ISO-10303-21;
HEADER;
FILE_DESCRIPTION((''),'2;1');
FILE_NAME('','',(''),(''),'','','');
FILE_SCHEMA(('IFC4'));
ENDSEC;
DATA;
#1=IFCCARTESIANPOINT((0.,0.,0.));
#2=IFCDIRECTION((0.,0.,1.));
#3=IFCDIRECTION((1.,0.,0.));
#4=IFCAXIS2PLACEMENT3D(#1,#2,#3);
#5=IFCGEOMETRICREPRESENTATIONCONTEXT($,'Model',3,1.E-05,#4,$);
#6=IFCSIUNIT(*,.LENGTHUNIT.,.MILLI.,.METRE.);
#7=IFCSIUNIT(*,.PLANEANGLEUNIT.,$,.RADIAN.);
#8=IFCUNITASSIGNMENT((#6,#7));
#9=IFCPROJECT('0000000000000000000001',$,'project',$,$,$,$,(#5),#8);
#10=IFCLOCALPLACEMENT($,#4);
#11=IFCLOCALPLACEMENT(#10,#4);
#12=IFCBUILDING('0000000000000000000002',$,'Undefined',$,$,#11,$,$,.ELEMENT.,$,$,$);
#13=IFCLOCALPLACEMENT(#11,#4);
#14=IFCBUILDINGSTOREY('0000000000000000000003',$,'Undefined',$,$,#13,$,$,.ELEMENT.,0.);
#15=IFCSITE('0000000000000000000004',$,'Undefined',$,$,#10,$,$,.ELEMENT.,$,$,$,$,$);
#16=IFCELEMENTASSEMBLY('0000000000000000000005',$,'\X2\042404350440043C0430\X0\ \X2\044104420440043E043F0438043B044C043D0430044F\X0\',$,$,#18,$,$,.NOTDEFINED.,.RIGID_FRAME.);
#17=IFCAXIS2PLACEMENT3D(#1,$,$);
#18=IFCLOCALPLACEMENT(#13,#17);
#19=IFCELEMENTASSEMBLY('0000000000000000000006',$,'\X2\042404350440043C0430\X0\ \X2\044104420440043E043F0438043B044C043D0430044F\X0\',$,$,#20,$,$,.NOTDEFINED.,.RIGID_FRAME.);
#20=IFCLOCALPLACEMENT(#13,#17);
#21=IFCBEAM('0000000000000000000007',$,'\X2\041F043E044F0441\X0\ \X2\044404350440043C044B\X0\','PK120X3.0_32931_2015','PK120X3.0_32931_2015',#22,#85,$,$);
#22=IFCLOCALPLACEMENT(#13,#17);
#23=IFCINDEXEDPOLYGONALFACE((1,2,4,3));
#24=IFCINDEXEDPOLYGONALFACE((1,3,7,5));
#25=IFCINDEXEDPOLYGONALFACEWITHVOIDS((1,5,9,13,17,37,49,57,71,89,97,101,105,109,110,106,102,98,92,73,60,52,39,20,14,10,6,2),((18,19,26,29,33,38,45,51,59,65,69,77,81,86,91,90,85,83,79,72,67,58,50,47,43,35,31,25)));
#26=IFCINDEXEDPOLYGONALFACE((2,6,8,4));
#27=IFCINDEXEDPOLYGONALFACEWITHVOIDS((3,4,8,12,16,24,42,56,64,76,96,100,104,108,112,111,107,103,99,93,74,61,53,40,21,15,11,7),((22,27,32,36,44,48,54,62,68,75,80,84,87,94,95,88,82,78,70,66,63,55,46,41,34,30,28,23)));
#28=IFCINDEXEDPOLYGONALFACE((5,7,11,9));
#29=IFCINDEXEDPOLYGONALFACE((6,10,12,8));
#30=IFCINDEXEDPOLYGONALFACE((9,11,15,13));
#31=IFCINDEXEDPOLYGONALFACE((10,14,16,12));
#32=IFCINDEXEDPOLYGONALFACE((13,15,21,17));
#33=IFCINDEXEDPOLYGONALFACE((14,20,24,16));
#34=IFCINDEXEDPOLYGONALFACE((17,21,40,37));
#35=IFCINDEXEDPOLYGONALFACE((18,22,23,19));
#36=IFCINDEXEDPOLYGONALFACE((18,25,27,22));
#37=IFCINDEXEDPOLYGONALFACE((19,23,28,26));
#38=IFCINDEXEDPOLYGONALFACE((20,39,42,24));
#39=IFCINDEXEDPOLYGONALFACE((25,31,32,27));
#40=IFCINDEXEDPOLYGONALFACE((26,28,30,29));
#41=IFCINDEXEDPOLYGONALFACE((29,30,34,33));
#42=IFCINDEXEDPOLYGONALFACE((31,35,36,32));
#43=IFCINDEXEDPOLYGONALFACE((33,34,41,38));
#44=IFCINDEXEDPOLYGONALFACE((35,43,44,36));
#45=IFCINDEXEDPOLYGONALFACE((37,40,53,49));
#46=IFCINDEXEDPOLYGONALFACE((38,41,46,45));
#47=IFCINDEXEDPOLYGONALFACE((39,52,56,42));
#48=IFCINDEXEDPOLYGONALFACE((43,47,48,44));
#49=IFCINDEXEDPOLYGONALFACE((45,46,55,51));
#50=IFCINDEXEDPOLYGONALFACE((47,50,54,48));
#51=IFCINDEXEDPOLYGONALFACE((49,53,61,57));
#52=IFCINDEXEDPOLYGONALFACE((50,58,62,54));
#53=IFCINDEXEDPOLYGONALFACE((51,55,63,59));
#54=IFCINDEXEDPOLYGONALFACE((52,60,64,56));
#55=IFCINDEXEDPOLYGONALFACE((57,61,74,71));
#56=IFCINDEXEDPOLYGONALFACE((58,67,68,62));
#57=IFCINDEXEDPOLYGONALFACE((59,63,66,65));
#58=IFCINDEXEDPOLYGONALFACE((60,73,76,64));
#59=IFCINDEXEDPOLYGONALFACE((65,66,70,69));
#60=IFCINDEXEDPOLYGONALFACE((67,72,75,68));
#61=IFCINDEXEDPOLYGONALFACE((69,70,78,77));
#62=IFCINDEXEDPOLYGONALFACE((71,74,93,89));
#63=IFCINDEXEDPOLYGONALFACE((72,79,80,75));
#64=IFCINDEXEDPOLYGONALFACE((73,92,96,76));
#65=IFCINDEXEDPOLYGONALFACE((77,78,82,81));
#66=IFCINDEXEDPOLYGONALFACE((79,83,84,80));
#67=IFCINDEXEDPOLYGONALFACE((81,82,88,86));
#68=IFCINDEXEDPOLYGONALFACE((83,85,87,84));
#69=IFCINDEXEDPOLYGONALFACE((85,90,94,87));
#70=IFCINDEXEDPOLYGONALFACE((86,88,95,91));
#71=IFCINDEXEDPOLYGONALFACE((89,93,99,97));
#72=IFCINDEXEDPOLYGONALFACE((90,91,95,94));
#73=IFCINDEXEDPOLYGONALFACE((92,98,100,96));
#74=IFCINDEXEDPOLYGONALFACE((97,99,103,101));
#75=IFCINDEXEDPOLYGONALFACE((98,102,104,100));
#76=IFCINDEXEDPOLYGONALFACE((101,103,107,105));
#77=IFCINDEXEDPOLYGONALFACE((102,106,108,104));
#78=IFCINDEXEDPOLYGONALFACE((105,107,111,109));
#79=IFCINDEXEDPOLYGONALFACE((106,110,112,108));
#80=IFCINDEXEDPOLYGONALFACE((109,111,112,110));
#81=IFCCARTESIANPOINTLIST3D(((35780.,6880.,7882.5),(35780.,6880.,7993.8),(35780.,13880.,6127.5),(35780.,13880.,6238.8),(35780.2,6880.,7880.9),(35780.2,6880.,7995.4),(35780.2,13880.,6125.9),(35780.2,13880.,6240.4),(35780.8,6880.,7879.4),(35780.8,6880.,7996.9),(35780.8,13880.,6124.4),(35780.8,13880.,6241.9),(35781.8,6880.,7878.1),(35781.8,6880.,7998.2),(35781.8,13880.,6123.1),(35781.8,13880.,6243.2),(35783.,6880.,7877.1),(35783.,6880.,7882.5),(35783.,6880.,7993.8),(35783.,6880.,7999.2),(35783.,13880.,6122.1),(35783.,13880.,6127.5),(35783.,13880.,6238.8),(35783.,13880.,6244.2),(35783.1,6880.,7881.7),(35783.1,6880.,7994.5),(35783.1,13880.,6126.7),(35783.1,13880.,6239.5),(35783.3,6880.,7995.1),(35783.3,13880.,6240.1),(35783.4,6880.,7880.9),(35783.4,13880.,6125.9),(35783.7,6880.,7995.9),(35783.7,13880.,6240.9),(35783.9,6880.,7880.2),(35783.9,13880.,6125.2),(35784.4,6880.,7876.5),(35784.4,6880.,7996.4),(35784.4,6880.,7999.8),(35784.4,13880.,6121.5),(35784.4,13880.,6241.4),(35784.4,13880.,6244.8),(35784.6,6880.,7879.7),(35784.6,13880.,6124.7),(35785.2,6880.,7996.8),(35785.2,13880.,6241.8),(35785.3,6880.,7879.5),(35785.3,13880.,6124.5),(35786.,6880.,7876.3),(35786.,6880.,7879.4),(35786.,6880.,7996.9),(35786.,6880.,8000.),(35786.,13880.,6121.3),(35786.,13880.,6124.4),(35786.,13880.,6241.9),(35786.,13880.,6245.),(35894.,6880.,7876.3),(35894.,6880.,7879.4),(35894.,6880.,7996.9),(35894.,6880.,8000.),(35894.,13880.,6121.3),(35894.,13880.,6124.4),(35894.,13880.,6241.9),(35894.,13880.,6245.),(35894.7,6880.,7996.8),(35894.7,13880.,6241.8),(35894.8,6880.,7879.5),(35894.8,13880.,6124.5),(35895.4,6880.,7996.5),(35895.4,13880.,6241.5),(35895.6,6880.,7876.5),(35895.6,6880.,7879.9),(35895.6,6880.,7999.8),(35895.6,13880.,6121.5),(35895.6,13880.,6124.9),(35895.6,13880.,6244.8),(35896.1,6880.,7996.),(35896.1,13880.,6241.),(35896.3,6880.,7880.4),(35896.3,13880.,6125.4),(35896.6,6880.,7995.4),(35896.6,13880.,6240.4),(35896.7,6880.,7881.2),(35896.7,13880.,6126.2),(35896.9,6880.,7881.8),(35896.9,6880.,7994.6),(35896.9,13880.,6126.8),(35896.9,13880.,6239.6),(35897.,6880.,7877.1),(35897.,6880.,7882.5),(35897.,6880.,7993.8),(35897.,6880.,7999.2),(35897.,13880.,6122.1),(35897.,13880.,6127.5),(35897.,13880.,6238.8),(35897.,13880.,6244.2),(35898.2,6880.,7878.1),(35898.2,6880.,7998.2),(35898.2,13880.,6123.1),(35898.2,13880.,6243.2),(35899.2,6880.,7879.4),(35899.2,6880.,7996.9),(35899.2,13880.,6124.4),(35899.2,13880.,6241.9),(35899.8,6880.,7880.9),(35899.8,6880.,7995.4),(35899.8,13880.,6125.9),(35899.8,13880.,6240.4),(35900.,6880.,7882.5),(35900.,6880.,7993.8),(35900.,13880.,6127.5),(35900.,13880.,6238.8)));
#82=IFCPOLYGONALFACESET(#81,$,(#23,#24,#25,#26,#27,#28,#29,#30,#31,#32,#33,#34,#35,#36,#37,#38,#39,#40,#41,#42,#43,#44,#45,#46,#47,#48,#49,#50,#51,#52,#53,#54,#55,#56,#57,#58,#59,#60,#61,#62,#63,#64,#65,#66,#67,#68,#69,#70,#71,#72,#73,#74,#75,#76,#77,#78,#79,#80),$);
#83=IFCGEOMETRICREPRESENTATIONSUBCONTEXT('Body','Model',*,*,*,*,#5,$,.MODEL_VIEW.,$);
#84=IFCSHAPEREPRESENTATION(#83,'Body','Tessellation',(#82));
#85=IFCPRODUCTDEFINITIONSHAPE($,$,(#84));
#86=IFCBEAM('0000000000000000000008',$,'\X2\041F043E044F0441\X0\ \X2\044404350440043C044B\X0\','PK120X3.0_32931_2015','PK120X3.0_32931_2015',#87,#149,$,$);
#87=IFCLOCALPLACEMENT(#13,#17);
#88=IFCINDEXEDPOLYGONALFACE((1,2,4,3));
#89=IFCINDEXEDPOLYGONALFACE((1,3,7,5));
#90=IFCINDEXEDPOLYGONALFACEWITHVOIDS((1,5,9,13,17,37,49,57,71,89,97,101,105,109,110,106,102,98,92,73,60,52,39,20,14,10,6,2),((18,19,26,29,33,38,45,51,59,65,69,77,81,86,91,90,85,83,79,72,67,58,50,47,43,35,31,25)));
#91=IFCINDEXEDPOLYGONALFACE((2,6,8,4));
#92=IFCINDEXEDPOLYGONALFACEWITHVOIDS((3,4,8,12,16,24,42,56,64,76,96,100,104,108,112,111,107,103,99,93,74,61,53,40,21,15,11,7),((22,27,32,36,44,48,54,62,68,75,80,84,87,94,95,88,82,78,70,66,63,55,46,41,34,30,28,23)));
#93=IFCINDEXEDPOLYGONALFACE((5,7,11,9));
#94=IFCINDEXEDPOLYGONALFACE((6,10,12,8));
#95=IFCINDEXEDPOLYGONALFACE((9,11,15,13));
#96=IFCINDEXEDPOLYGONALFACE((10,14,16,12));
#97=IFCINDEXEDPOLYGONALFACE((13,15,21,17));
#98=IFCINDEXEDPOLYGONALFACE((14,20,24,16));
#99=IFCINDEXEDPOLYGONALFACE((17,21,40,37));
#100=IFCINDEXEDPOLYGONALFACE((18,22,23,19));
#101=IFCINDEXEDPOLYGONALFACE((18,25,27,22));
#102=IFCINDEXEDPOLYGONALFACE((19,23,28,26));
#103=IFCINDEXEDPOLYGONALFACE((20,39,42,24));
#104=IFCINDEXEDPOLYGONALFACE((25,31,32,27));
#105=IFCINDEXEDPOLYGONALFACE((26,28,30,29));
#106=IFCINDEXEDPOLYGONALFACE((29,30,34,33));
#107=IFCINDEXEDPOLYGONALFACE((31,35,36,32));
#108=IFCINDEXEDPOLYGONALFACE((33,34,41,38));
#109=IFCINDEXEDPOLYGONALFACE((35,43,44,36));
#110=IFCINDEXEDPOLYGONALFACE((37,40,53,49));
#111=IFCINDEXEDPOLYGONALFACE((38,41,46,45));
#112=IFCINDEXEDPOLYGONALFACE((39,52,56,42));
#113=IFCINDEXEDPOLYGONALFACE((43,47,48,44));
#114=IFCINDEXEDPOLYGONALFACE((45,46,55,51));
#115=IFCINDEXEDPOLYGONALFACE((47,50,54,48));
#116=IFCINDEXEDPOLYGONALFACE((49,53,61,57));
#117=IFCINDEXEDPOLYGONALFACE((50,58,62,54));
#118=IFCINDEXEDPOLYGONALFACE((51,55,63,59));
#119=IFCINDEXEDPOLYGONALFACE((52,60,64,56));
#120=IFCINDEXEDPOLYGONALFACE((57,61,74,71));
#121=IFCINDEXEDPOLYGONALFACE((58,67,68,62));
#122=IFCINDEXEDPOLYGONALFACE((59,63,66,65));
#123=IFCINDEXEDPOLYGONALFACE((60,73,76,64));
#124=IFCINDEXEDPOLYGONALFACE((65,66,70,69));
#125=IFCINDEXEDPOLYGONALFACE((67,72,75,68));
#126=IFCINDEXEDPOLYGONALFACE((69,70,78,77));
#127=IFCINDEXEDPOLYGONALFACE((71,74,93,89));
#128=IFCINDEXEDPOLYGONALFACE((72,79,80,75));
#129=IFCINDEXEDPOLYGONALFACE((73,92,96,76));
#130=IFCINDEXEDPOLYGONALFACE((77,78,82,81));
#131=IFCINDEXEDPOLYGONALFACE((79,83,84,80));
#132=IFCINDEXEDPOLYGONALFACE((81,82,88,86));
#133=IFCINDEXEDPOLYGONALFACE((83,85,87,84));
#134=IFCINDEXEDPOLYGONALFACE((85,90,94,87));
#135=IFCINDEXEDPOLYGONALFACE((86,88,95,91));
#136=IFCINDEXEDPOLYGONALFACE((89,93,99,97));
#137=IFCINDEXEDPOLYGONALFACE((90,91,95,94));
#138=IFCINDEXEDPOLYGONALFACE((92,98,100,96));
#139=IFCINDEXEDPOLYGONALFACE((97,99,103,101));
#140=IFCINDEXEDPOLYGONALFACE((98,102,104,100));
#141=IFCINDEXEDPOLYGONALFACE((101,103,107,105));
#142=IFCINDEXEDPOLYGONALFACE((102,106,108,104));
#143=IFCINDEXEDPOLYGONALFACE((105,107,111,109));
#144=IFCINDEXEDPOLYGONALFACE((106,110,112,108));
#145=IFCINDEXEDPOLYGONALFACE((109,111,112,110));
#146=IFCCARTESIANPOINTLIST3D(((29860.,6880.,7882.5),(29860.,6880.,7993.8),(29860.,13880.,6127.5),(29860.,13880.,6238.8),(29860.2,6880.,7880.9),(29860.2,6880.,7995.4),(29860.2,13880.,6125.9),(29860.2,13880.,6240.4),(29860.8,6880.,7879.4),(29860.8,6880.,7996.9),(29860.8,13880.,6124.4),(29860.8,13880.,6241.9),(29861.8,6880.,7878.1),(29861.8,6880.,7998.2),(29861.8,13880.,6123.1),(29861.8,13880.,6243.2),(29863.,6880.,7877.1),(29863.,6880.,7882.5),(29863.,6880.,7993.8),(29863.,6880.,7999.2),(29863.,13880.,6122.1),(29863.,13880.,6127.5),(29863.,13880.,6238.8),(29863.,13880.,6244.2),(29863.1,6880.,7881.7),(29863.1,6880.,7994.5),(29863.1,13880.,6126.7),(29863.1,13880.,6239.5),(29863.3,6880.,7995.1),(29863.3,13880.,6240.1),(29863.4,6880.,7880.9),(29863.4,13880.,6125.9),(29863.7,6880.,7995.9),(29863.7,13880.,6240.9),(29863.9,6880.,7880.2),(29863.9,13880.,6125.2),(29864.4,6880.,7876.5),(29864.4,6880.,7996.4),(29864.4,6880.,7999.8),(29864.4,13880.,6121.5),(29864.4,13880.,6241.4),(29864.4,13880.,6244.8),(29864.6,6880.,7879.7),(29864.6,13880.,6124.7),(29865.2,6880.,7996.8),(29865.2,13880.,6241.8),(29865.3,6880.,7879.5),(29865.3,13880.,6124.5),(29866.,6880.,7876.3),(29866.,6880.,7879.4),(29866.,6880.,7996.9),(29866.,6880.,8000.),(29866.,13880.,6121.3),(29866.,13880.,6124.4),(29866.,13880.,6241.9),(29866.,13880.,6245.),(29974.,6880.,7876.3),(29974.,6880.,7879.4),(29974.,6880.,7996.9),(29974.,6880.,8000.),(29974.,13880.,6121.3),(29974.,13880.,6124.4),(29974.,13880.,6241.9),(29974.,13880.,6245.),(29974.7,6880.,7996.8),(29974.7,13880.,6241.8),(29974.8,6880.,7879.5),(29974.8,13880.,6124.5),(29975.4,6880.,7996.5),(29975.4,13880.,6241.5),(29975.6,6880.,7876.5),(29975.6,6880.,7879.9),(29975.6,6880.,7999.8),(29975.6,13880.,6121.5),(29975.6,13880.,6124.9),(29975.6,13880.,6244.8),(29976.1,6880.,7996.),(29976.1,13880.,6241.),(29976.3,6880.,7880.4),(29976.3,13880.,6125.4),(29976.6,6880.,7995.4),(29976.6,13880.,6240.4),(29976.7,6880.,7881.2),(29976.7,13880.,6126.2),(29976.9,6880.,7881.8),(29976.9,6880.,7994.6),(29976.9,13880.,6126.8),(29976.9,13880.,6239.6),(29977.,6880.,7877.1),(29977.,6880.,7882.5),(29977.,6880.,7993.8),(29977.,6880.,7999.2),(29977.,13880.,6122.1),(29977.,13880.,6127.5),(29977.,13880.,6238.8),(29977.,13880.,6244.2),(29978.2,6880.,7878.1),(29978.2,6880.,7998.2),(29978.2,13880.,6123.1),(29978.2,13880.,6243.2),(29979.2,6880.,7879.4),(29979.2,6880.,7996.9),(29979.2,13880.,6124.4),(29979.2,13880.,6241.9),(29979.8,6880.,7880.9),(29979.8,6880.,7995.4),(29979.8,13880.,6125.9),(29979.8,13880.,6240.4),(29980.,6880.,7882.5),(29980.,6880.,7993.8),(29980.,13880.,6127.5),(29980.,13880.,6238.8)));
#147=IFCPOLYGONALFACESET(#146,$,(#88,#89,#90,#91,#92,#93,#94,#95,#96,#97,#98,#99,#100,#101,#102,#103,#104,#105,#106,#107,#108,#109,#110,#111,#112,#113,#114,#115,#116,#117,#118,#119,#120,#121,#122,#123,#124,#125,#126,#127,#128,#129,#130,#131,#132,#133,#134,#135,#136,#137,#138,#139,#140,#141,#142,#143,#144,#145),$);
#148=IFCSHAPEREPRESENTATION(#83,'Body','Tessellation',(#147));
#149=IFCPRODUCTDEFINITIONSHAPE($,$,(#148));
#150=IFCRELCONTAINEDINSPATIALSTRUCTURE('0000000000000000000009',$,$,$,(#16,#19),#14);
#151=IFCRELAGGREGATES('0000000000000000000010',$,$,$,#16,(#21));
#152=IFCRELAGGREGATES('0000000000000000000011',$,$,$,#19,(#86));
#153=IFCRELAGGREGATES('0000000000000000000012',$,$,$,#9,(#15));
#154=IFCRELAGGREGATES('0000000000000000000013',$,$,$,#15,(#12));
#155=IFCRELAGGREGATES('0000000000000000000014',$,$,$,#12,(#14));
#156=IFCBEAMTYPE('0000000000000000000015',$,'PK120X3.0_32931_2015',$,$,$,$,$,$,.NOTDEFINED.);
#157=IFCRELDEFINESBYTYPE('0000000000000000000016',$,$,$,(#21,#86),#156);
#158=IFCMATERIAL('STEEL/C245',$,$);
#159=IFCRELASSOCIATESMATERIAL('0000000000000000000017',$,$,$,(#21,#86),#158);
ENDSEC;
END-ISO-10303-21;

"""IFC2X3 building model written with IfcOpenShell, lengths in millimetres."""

from ifc_helpers import new_model, si_unit, frame, origin_with_axes, origin_2d_with_axis, place, context, subcontext, project, spatial, hollow_rectangle, extrude, clip, halfspace, material, type_object, element, aggregate, save


model = new_model("IFC2X3")

# Units and contexts
model_context = context("Model", 3, precision=1e-05, world=origin_with_axes())
body_context = subcontext(model_context, "Body", "Model", "MODEL_VIEW")
ifc_project = project(units=[si_unit("LENGTHUNIT", "METRE", prefix="MILLI"), si_unit("PLANEANGLEUNIT", "RADIAN")], contexts=[model_context])

# Site, building, storey
site_placement = place(None, origin_with_axes())
site = spatial("IfcSite", under=ifc_project, at=site_placement, Name="Undefined", CompositionType="ELEMENT")
building_placement = place(site_placement, origin_with_axes())
building = spatial("IfcBuilding", under=site, at=building_placement, Name="Undefined", CompositionType="ELEMENT")
storey_placement = place(building_placement, origin_with_axes())
storey = spatial("IfcBuildingStorey", under=building, at=storey_placement, Name="Undefined", CompositionType="ELEMENT", Elevation=0.0)

# Shared definitions
ifc_material = material(Name="STEEL/C245")

# Element assemblies
assembly_1_placement = place(storey_placement, origin_with_axes())
assembly_1 = element("IfcElementAssembly", 1, at=assembly_1_placement, inside=storey, Name="Ферма стропильная", AssemblyPlace="NOTDEFINED", PredefinedType="RIGID_FRAME")
assembly_2_placement = place(storey_placement, origin_with_axes())
assembly_2 = element("IfcElementAssembly", 2, at=assembly_2_placement, inside=storey, Name="Ферма стропильная", AssemblyPlace="NOTDEFINED", PredefinedType="RIGID_FRAME")

# Beams
beam_type_1 = type_object("IfcBeamType", Name="PK120X3.0_32931_2015", PredefinedType="NOTDEFINED")
beam_1_placement = place(assembly_1_placement, frame((35840.0, 13865.4, 6186.8), z_axis=(0.0, 0.243188, 0.969979), x_axis=(0.0, -0.969979, 0.243188)))
beam_1 = element("IfcBeam", 3, at=beam_1_placement, type_object=beam_type_1, material=ifc_material, Name="Пояс фермы", Description="PK120X3.0_32931_2015", ObjectType="PK120X3.0_32931_2015", context=body_context, shape_type="Clipping", body=[
    clip(clip(extrude(hollow_rectangle(XDim=120.0, YDim=120.0, WallThickness=3.0, InnerFilletRadius=3.0, OuterFilletRadius=6.0, at=origin_2d_with_axis()), frame((7232.0, 0.0, 0.0), z_axis=(-1.0, 0.0, 0.0), x_axis=(0.0, -1.0, 0.0)), (0.0, 0.0, 1.0), 7277.4), halfspace(frame((7216.6, 0.0, 60.0), z_axis=(0.969979, 0.0, -0.243188), x_axis=(0.243188, 0.0, 0.969979)), False)), halfspace(frame((0.0, 0.0, 60.0), z_axis=(0.969979, 0.0, -0.243188), x_axis=(0.243188, 0.0, 0.969979)), True)),
])
aggregate(assembly_1, [beam_1])
beam_2_placement = place(assembly_2_placement, frame((29920.0, 13865.4, 6186.8), z_axis=(0.0, 0.243188, 0.969979), x_axis=(0.0, -0.969979, 0.243188)))
beam_2 = element("IfcBeam", 4, at=beam_2_placement, type_object=beam_type_1, material=ifc_material, Name="Пояс фермы", Description="PK120X3.0_32931_2015", ObjectType="PK120X3.0_32931_2015", context=body_context, shape_type="Clipping", body=[
    clip(clip(extrude(hollow_rectangle(XDim=120.0, YDim=120.0, WallThickness=3.0, InnerFilletRadius=3.0, OuterFilletRadius=6.0, at=origin_2d_with_axis()), frame((7232.0, 0.0, 0.0), z_axis=(-1.0, 0.0, 0.0), x_axis=(0.0, -1.0, 0.0)), (0.0, 0.0, 1.0), 7277.4), halfspace(frame((7216.6, 0.0, 60.0), z_axis=(0.969979, 0.0, -0.243188), x_axis=(0.243188, 0.0, 0.969979)), False)), halfspace(frame((0.0, 0.0, 60.0), z_axis=(0.969979, 0.0, -0.243188), x_axis=(0.243188, 0.0, 0.969979)), True)),
])
aggregate(assembly_2, [beam_2])

save(model, "model.ifc")
